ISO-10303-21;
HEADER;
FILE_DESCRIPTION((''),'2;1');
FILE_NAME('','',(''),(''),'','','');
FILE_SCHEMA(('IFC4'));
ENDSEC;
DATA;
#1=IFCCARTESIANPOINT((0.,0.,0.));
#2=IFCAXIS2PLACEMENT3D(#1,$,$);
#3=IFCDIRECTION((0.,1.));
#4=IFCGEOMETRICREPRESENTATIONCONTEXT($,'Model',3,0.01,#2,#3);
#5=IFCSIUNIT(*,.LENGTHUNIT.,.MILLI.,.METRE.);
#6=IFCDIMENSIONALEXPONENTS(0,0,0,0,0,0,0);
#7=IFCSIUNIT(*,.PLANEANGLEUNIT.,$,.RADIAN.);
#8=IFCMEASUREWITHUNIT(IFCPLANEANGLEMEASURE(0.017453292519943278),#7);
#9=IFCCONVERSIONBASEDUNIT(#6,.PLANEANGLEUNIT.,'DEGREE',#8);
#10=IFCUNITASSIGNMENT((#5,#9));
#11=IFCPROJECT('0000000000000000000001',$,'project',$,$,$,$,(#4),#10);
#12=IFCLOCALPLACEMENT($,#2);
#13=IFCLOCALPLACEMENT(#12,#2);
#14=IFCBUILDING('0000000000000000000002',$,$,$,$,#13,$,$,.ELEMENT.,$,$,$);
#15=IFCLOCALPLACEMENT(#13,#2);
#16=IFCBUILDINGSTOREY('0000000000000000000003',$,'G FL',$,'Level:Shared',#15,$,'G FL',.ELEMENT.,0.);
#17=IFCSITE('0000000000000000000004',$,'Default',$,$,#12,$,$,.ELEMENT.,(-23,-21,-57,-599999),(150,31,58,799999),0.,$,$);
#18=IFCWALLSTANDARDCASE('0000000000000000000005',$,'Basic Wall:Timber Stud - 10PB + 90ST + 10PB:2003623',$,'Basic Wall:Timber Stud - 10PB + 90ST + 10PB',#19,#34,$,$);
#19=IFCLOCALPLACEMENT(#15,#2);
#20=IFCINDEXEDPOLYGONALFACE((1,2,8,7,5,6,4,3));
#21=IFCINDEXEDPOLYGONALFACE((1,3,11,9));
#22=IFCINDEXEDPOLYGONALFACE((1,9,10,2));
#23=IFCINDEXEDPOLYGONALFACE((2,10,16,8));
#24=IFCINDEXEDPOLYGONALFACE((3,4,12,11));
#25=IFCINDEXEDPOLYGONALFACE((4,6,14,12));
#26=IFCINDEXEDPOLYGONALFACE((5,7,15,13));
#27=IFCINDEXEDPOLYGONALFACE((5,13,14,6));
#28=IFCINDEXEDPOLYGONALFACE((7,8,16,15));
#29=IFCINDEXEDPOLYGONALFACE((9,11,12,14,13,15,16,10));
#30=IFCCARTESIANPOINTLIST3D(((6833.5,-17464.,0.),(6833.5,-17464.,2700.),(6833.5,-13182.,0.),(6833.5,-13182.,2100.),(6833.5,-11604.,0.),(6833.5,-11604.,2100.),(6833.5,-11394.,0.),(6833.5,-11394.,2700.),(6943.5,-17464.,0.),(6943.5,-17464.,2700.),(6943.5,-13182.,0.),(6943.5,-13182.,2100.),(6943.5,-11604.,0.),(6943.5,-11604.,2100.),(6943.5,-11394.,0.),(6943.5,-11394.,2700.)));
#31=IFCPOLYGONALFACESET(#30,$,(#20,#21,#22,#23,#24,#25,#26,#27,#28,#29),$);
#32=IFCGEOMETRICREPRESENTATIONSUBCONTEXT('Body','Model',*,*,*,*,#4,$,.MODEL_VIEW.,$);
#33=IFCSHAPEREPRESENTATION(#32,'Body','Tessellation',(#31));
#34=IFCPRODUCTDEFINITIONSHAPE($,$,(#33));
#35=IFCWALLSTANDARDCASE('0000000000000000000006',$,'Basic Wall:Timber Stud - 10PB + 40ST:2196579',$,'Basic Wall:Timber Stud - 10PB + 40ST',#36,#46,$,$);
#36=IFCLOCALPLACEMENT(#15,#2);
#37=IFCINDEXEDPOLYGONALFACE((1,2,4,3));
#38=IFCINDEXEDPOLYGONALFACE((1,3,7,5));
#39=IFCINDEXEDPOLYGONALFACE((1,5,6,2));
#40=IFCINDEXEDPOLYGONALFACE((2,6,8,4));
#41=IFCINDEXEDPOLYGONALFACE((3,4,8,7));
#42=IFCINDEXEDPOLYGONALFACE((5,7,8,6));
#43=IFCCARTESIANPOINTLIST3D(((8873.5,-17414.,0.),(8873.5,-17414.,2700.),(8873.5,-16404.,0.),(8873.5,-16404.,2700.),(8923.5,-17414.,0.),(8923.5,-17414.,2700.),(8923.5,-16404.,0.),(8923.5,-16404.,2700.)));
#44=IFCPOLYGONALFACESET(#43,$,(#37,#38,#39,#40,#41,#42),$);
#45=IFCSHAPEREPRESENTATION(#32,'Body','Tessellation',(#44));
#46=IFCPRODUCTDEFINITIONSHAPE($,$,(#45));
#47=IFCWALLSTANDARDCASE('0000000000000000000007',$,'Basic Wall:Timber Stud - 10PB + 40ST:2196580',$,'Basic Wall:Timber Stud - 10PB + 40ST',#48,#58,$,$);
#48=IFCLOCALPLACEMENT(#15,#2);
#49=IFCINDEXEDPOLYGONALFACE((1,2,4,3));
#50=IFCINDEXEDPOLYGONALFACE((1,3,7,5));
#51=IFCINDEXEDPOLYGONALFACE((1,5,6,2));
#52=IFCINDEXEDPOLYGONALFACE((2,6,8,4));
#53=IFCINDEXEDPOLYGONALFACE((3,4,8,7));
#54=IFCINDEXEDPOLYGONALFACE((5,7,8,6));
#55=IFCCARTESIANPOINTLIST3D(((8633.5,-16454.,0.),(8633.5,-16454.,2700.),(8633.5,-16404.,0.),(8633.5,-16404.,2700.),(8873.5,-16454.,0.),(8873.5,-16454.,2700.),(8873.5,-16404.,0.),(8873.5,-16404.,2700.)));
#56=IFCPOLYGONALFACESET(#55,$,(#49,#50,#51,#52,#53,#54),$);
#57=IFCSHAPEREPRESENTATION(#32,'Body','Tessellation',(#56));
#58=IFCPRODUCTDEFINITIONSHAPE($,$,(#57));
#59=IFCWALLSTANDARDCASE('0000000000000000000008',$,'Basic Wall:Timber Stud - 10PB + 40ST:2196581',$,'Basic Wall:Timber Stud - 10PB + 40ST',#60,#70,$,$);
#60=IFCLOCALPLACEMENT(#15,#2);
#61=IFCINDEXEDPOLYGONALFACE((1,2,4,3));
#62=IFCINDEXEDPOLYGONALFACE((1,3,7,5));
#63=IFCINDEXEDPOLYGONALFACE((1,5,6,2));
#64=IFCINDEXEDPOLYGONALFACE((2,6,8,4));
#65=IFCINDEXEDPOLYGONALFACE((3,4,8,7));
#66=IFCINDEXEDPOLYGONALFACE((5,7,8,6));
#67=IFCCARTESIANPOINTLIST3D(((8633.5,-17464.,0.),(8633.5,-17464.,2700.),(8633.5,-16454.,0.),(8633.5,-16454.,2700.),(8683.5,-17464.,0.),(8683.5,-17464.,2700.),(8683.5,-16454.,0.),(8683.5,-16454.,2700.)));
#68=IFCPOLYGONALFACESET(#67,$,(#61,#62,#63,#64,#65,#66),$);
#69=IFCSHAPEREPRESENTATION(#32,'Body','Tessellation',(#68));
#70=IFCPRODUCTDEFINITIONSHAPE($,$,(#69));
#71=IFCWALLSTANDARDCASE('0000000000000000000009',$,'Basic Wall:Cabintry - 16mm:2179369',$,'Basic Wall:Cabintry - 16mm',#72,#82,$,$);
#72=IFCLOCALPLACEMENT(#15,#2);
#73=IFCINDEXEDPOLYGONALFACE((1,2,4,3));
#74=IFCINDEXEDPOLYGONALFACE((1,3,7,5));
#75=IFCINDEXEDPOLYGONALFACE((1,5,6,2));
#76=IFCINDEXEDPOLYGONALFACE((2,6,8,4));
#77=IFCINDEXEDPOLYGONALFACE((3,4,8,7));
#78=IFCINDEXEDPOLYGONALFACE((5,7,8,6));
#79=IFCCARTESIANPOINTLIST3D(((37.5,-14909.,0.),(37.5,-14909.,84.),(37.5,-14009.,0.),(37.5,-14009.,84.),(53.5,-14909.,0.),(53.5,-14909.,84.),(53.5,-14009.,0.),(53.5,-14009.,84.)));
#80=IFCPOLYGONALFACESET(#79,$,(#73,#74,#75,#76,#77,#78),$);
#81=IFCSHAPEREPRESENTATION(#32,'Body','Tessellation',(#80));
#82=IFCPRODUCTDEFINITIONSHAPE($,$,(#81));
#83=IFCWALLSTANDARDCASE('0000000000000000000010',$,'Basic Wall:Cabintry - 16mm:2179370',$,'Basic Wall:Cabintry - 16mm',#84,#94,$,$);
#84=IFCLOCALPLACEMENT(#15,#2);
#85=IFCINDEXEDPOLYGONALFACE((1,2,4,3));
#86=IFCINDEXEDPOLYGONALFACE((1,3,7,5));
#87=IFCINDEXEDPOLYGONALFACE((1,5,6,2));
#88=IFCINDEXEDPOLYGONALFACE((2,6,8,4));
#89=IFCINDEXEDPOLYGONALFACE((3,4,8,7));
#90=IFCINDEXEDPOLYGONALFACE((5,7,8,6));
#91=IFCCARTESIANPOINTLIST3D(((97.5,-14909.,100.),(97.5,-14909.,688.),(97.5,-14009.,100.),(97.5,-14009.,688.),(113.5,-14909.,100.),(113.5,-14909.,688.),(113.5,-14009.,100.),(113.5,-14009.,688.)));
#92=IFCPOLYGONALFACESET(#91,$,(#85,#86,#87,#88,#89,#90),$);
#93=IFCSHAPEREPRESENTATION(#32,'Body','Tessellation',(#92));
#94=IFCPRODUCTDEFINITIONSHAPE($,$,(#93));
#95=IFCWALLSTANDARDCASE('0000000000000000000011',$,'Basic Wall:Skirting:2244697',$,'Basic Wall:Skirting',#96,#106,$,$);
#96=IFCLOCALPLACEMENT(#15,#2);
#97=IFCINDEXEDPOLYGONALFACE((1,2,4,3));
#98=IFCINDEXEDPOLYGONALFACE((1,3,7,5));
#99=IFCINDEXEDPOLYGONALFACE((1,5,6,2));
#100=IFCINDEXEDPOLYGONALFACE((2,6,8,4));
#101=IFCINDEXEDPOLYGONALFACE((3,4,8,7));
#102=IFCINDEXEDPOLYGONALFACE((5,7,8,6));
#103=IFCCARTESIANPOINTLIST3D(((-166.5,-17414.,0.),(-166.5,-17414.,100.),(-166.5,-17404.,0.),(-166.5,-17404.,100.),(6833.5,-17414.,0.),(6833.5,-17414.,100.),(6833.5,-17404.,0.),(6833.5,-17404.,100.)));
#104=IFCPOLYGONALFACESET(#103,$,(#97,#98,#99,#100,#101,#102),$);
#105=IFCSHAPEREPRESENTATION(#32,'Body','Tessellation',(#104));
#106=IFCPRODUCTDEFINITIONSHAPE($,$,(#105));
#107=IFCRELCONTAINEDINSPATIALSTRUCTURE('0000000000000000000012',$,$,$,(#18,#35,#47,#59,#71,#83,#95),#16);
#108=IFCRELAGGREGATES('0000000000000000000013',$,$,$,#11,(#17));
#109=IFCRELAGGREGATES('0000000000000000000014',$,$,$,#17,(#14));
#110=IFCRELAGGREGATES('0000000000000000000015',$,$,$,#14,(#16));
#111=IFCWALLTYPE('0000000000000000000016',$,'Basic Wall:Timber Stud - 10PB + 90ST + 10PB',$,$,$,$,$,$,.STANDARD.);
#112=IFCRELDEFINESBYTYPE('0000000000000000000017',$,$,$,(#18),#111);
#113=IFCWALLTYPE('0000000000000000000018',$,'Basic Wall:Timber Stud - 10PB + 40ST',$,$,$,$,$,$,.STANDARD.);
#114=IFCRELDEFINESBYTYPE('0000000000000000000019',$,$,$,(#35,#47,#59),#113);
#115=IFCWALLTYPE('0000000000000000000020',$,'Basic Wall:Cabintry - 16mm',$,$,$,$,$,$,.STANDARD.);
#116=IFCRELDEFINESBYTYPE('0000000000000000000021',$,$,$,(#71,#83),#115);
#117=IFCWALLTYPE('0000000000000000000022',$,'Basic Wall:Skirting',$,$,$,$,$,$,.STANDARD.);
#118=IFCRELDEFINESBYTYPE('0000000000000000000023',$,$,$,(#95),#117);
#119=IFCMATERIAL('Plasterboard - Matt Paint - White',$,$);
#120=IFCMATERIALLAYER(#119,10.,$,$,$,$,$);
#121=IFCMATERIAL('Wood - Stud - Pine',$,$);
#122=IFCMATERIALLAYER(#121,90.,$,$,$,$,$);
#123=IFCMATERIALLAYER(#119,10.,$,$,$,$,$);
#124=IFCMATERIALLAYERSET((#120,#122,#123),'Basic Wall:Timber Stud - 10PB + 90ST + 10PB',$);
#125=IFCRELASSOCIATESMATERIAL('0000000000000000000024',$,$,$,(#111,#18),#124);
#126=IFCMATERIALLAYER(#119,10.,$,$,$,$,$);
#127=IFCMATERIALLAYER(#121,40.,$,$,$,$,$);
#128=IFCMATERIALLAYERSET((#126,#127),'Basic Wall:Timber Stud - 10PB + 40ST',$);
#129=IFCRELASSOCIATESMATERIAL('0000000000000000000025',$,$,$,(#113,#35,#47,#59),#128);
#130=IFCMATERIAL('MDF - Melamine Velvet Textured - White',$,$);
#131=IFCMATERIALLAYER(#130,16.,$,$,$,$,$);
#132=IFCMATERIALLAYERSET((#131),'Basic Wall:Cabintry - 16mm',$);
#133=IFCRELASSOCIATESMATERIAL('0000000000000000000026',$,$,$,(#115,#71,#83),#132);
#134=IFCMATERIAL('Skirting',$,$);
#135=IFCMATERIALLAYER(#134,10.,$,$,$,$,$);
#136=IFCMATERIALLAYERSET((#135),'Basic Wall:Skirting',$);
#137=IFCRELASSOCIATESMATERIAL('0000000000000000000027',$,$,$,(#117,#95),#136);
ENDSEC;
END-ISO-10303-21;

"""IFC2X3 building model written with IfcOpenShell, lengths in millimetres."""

from ifc_helpers import new_model, entity, si_unit, converted_unit, direction, frame, frame_2d, origin, place, context, subcontext, project, spatial, polyline, rectangle, extrude, clip, bounded_halfspace, material, layer, layer_set, layer_usage, type_object, element, save


model = new_model("IFC2X3")

# Units and contexts
model_context = context("Model", 3, precision=0.01, world=origin(), true_north=direction((0.0, 1.0)))
body_context = subcontext(model_context, "Body", "Model", "MODEL_VIEW")
ifc_project = project(units=[si_unit("LENGTHUNIT", "METRE", prefix="MILLI"), converted_unit("PLANEANGLEUNIT", "DEGREE", entity("IfcPlaneAngleMeasure", 0.017453292519943278), si_unit("PLANEANGLEUNIT", "RADIAN"), dimensions=[0, 0, 0, 0, 0, 0, 0])], contexts=[model_context])

# Site, building, storey
site_placement = place(None, origin())
site = spatial("IfcSite", under=ifc_project, at=site_placement, Name="Default", CompositionType="ELEMENT", RefLatitude=(-23, -21, -57, -599999), RefLongitude=(150, 31, 58, 799999), RefElevation=0.0)
building_placement = place(site_placement, origin())
building = spatial("IfcBuilding", under=site, at=building_placement, CompositionType="ELEMENT")
storey_placement = place(building_placement, origin())
storey = spatial("IfcBuildingStorey", under=building, at=storey_placement, Name="G FL", ObjectType="Level:Shared", LongName="G FL", CompositionType="ELEMENT", Elevation=0.0)

# Wall, opening
ifc_material_1 = material(Name="Plasterboard - Matt Paint - White")
ifc_layer_1 = layer(ifc_material_1, 10.0)
ifc_material_2 = material(Name="Wood - Stud - Pine")
ifc_layer_2 = layer(ifc_material_2, 90.0)
ifc_layer_3 = layer(ifc_material_1, 10.0)
ifc_layer_set_1 = layer_set([ifc_layer_1, ifc_layer_2, ifc_layer_3], Name="Basic Wall:Timber Stud - 10PB + 90ST + 10PB")
ifc_layer_usage_1 = layer_usage(ifc_layer_set_1, "AXIS2", "POSITIVE", -55.0)
wall_type_1 = type_object("IfcWallType", Name="Basic Wall:Timber Stud - 10PB + 90ST + 10PB", PredefinedType="STANDARD", material=ifc_layer_set_1)
wall_1_placement = place(storey_placement, frame((6888.5, -17464.0, 0.0), z_axis=(0.0, 0.0, 1.0), x_axis=(0.0, 1.0, 0.0)))
wall_1 = element("IfcWallStandardCase", 1, at=wall_1_placement, inside=storey, type_object=wall_type_1, material=ifc_layer_usage_1, Name="Basic Wall:Timber Stud - 10PB + 90ST + 10PB:2003623", ObjectType="Basic Wall:Timber Stud - 10PB + 90ST + 10PB", context=body_context, shape_type="SweptSolid", body=[
    extrude(rectangle(XDim=6070.0, YDim=110.0, at=frame_2d((3035.0, 0.0), x_axis=(-1.0, 0.0))), origin(), (0.0, 0.0, 1.0), 2700.0),
])
opening_1_placement = place(wall_1_placement, frame((4282.0, -55.0, 0.0)))
element("IfcOpeningElement", 2, at=opening_1_placement, cuts=wall_1, ObjectType="Opening", context=body_context, shape_type="SweptSolid", body=[
    extrude(rectangle(XDim=2100.0, YDim=1578.0, at=frame_2d((1050.0, 789.0), x_axis=(1.0, 0.0))), frame((0.0, 0.0, 0.0), z_axis=(0.0, 1.0, 0.0), x_axis=(0.0, 0.0, 1.0)), (0.0, 0.0, 1.0), 110.0),
])

# Walls
ifc_layer_4 = layer(ifc_material_1, 10.0)
ifc_layer_5 = layer(ifc_material_2, 40.0)
ifc_layer_set_2 = layer_set([ifc_layer_4, ifc_layer_5], Name="Basic Wall:Timber Stud - 10PB + 40ST")
ifc_layer_usage_2 = layer_usage(ifc_layer_set_2, "AXIS2", "NEGATIVE", 25.0)
wall_type_2 = type_object("IfcWallType", Name="Basic Wall:Timber Stud - 10PB + 40ST", PredefinedType="STANDARD", material=ifc_layer_set_2)
wall_2_placement = place(storey_placement, frame((8898.5, -16404.0, 0.0), z_axis=(0.0, 0.0, 1.0), x_axis=(0.0, -1.0, 0.0)))
element("IfcWallStandardCase", 3, at=wall_2_placement, inside=storey, type_object=wall_type_2, material=ifc_layer_usage_2, Name="Basic Wall:Timber Stud - 10PB + 40ST:2196579", ObjectType="Basic Wall:Timber Stud - 10PB + 40ST", context=body_context, shape_type="SweptSolid", body=[
    extrude(rectangle(XDim=1010.0, YDim=50.0, at=frame_2d((505.0, 0.0), x_axis=(-1.0, 0.0))), origin(), (0.0, 0.0, 1.0), 2700.0),
])
ifc_layer_usage_3 = layer_usage(ifc_layer_set_2, "AXIS2", "POSITIVE", -25.0)
wall_3_placement = place(storey_placement, frame((8873.5, -16429.0, 0.0), z_axis=(0.0, 0.0, 1.0), x_axis=(-1.0, 0.0, 0.0)))
element("IfcWallStandardCase", 4, at=wall_3_placement, inside=storey, type_object=wall_type_2, material=ifc_layer_usage_3, Name="Basic Wall:Timber Stud - 10PB + 40ST:2196580", ObjectType="Basic Wall:Timber Stud - 10PB + 40ST", context=body_context, shape_type="SweptSolid", body=[
    extrude(rectangle(XDim=240.0, YDim=50.0, at=frame_2d((120.0, 0.0), x_axis=(-1.0, 0.0))), origin(), (0.0, 0.0, 1.0), 2700.0),
])
ifc_layer_usage_4 = layer_usage(ifc_layer_set_2, "AXIS2", "NEGATIVE", 25.0)
wall_4_placement = place(storey_placement, frame((8658.5, -17464.0, 0.0), z_axis=(0.0, 0.0, 1.0), x_axis=(0.0, 1.0, 0.0)))
element("IfcWallStandardCase", 5, at=wall_4_placement, inside=storey, type_object=wall_type_2, material=ifc_layer_usage_4, Name="Basic Wall:Timber Stud - 10PB + 40ST:2196581", ObjectType="Basic Wall:Timber Stud - 10PB + 40ST", context=body_context, shape_type="SweptSolid", body=[
    extrude(rectangle(XDim=1010.0, YDim=50.0, at=frame_2d((505.0, 0.0), x_axis=(-1.0, 0.0))), origin(), (0.0, 0.0, 1.0), 2700.0),
])

# Walls
ifc_material_3 = material(Name="MDF - Melamine Velvet Textured - White")
ifc_layer_6 = layer(ifc_material_3, 16.0)
ifc_layer_set_3 = layer_set([ifc_layer_6], Name="Basic Wall:Cabintry - 16mm")
ifc_layer_usage_5 = layer_usage(ifc_layer_set_3, "AXIS2", "NEGATIVE", 8.0)
wall_type_3 = type_object("IfcWallType", Name="Basic Wall:Cabintry - 16mm", PredefinedType="STANDARD", material=ifc_layer_set_3)
wall_5_placement = place(storey_placement, frame((45.5, -14909.0, 0.0), z_axis=(0.0, 0.0, 1.0), x_axis=(0.0, 1.0, 0.0)))
element("IfcWallStandardCase", 6, at=wall_5_placement, inside=storey, type_object=wall_type_3, material=ifc_layer_usage_5, Name="Basic Wall:Cabintry - 16mm:2179369", ObjectType="Basic Wall:Cabintry - 16mm", context=body_context, shape_type="Clipping", body=[
    clip(extrude(rectangle(XDim=900.0, YDim=16.0, at=frame_2d((450.0, 0.0), x_axis=(-1.0, 0.0))), origin(), (0.0, 0.0, 1.0), 84.0), bounded_halfspace(frame((0.0, -8.0, 84.0), z_axis=(0.0, 0.0, -1.0), x_axis=(-1.0, 0.0, 0.0)), True, frame((0.0, -8.0, 84.0)), polyline([(0.0, 0.0), (900.0, 0.0), (900.0, 16.0), (16.0, 16.0), (0.0, 16.0), (0.0, 0.0)]))),
])
ifc_layer_usage_6 = layer_usage(ifc_layer_set_3, "AXIS2", "NEGATIVE", 8.0)
wall_6_placement = place(storey_placement, frame((105.5, -14909.0, 100.0), z_axis=(0.0, 0.0, 1.0), x_axis=(0.0, 1.0, 0.0)))
element("IfcWallStandardCase", 7, at=wall_6_placement, inside=storey, type_object=wall_type_3, material=ifc_layer_usage_6, Name="Basic Wall:Cabintry - 16mm:2179370", ObjectType="Basic Wall:Cabintry - 16mm", context=body_context, shape_type="SweptSolid", body=[
    extrude(rectangle(XDim=900.0, YDim=16.0, at=frame_2d((450.0, 0.0), x_axis=(-1.0, 0.0))), origin(), (0.0, 0.0, 1.0), 588.0),
])
ifc_material_4 = material(Name="Skirting")
ifc_layer_7 = layer(ifc_material_4, 10.0)
ifc_layer_set_4 = layer_set([ifc_layer_7], Name="Basic Wall:Skirting")
ifc_layer_usage_7 = layer_usage(ifc_layer_set_4, "AXIS2", "NEGATIVE", 5.0)
wall_type_4 = type_object("IfcWallType", Name="Basic Wall:Skirting", PredefinedType="STANDARD", material=ifc_layer_set_4)
wall_7_placement = place(storey_placement, frame((6833.5, -17409.0, 0.0), z_axis=(0.0, 0.0, 1.0), x_axis=(-1.0, 0.0, 0.0)))
element("IfcWallStandardCase", 8, at=wall_7_placement, inside=storey, type_object=wall_type_4, material=ifc_layer_usage_7, Name="Basic Wall:Skirting:2244697", ObjectType="Basic Wall:Skirting", context=body_context, shape_type="SweptSolid", body=[
    extrude(rectangle(XDim=7000.0, YDim=10.0, at=frame_2d((3500.0, 0.0), x_axis=(-1.0, 0.0))), origin(), (0.0, 0.0, 1.0), 100.0),
])

save(model, "model.ifc")
